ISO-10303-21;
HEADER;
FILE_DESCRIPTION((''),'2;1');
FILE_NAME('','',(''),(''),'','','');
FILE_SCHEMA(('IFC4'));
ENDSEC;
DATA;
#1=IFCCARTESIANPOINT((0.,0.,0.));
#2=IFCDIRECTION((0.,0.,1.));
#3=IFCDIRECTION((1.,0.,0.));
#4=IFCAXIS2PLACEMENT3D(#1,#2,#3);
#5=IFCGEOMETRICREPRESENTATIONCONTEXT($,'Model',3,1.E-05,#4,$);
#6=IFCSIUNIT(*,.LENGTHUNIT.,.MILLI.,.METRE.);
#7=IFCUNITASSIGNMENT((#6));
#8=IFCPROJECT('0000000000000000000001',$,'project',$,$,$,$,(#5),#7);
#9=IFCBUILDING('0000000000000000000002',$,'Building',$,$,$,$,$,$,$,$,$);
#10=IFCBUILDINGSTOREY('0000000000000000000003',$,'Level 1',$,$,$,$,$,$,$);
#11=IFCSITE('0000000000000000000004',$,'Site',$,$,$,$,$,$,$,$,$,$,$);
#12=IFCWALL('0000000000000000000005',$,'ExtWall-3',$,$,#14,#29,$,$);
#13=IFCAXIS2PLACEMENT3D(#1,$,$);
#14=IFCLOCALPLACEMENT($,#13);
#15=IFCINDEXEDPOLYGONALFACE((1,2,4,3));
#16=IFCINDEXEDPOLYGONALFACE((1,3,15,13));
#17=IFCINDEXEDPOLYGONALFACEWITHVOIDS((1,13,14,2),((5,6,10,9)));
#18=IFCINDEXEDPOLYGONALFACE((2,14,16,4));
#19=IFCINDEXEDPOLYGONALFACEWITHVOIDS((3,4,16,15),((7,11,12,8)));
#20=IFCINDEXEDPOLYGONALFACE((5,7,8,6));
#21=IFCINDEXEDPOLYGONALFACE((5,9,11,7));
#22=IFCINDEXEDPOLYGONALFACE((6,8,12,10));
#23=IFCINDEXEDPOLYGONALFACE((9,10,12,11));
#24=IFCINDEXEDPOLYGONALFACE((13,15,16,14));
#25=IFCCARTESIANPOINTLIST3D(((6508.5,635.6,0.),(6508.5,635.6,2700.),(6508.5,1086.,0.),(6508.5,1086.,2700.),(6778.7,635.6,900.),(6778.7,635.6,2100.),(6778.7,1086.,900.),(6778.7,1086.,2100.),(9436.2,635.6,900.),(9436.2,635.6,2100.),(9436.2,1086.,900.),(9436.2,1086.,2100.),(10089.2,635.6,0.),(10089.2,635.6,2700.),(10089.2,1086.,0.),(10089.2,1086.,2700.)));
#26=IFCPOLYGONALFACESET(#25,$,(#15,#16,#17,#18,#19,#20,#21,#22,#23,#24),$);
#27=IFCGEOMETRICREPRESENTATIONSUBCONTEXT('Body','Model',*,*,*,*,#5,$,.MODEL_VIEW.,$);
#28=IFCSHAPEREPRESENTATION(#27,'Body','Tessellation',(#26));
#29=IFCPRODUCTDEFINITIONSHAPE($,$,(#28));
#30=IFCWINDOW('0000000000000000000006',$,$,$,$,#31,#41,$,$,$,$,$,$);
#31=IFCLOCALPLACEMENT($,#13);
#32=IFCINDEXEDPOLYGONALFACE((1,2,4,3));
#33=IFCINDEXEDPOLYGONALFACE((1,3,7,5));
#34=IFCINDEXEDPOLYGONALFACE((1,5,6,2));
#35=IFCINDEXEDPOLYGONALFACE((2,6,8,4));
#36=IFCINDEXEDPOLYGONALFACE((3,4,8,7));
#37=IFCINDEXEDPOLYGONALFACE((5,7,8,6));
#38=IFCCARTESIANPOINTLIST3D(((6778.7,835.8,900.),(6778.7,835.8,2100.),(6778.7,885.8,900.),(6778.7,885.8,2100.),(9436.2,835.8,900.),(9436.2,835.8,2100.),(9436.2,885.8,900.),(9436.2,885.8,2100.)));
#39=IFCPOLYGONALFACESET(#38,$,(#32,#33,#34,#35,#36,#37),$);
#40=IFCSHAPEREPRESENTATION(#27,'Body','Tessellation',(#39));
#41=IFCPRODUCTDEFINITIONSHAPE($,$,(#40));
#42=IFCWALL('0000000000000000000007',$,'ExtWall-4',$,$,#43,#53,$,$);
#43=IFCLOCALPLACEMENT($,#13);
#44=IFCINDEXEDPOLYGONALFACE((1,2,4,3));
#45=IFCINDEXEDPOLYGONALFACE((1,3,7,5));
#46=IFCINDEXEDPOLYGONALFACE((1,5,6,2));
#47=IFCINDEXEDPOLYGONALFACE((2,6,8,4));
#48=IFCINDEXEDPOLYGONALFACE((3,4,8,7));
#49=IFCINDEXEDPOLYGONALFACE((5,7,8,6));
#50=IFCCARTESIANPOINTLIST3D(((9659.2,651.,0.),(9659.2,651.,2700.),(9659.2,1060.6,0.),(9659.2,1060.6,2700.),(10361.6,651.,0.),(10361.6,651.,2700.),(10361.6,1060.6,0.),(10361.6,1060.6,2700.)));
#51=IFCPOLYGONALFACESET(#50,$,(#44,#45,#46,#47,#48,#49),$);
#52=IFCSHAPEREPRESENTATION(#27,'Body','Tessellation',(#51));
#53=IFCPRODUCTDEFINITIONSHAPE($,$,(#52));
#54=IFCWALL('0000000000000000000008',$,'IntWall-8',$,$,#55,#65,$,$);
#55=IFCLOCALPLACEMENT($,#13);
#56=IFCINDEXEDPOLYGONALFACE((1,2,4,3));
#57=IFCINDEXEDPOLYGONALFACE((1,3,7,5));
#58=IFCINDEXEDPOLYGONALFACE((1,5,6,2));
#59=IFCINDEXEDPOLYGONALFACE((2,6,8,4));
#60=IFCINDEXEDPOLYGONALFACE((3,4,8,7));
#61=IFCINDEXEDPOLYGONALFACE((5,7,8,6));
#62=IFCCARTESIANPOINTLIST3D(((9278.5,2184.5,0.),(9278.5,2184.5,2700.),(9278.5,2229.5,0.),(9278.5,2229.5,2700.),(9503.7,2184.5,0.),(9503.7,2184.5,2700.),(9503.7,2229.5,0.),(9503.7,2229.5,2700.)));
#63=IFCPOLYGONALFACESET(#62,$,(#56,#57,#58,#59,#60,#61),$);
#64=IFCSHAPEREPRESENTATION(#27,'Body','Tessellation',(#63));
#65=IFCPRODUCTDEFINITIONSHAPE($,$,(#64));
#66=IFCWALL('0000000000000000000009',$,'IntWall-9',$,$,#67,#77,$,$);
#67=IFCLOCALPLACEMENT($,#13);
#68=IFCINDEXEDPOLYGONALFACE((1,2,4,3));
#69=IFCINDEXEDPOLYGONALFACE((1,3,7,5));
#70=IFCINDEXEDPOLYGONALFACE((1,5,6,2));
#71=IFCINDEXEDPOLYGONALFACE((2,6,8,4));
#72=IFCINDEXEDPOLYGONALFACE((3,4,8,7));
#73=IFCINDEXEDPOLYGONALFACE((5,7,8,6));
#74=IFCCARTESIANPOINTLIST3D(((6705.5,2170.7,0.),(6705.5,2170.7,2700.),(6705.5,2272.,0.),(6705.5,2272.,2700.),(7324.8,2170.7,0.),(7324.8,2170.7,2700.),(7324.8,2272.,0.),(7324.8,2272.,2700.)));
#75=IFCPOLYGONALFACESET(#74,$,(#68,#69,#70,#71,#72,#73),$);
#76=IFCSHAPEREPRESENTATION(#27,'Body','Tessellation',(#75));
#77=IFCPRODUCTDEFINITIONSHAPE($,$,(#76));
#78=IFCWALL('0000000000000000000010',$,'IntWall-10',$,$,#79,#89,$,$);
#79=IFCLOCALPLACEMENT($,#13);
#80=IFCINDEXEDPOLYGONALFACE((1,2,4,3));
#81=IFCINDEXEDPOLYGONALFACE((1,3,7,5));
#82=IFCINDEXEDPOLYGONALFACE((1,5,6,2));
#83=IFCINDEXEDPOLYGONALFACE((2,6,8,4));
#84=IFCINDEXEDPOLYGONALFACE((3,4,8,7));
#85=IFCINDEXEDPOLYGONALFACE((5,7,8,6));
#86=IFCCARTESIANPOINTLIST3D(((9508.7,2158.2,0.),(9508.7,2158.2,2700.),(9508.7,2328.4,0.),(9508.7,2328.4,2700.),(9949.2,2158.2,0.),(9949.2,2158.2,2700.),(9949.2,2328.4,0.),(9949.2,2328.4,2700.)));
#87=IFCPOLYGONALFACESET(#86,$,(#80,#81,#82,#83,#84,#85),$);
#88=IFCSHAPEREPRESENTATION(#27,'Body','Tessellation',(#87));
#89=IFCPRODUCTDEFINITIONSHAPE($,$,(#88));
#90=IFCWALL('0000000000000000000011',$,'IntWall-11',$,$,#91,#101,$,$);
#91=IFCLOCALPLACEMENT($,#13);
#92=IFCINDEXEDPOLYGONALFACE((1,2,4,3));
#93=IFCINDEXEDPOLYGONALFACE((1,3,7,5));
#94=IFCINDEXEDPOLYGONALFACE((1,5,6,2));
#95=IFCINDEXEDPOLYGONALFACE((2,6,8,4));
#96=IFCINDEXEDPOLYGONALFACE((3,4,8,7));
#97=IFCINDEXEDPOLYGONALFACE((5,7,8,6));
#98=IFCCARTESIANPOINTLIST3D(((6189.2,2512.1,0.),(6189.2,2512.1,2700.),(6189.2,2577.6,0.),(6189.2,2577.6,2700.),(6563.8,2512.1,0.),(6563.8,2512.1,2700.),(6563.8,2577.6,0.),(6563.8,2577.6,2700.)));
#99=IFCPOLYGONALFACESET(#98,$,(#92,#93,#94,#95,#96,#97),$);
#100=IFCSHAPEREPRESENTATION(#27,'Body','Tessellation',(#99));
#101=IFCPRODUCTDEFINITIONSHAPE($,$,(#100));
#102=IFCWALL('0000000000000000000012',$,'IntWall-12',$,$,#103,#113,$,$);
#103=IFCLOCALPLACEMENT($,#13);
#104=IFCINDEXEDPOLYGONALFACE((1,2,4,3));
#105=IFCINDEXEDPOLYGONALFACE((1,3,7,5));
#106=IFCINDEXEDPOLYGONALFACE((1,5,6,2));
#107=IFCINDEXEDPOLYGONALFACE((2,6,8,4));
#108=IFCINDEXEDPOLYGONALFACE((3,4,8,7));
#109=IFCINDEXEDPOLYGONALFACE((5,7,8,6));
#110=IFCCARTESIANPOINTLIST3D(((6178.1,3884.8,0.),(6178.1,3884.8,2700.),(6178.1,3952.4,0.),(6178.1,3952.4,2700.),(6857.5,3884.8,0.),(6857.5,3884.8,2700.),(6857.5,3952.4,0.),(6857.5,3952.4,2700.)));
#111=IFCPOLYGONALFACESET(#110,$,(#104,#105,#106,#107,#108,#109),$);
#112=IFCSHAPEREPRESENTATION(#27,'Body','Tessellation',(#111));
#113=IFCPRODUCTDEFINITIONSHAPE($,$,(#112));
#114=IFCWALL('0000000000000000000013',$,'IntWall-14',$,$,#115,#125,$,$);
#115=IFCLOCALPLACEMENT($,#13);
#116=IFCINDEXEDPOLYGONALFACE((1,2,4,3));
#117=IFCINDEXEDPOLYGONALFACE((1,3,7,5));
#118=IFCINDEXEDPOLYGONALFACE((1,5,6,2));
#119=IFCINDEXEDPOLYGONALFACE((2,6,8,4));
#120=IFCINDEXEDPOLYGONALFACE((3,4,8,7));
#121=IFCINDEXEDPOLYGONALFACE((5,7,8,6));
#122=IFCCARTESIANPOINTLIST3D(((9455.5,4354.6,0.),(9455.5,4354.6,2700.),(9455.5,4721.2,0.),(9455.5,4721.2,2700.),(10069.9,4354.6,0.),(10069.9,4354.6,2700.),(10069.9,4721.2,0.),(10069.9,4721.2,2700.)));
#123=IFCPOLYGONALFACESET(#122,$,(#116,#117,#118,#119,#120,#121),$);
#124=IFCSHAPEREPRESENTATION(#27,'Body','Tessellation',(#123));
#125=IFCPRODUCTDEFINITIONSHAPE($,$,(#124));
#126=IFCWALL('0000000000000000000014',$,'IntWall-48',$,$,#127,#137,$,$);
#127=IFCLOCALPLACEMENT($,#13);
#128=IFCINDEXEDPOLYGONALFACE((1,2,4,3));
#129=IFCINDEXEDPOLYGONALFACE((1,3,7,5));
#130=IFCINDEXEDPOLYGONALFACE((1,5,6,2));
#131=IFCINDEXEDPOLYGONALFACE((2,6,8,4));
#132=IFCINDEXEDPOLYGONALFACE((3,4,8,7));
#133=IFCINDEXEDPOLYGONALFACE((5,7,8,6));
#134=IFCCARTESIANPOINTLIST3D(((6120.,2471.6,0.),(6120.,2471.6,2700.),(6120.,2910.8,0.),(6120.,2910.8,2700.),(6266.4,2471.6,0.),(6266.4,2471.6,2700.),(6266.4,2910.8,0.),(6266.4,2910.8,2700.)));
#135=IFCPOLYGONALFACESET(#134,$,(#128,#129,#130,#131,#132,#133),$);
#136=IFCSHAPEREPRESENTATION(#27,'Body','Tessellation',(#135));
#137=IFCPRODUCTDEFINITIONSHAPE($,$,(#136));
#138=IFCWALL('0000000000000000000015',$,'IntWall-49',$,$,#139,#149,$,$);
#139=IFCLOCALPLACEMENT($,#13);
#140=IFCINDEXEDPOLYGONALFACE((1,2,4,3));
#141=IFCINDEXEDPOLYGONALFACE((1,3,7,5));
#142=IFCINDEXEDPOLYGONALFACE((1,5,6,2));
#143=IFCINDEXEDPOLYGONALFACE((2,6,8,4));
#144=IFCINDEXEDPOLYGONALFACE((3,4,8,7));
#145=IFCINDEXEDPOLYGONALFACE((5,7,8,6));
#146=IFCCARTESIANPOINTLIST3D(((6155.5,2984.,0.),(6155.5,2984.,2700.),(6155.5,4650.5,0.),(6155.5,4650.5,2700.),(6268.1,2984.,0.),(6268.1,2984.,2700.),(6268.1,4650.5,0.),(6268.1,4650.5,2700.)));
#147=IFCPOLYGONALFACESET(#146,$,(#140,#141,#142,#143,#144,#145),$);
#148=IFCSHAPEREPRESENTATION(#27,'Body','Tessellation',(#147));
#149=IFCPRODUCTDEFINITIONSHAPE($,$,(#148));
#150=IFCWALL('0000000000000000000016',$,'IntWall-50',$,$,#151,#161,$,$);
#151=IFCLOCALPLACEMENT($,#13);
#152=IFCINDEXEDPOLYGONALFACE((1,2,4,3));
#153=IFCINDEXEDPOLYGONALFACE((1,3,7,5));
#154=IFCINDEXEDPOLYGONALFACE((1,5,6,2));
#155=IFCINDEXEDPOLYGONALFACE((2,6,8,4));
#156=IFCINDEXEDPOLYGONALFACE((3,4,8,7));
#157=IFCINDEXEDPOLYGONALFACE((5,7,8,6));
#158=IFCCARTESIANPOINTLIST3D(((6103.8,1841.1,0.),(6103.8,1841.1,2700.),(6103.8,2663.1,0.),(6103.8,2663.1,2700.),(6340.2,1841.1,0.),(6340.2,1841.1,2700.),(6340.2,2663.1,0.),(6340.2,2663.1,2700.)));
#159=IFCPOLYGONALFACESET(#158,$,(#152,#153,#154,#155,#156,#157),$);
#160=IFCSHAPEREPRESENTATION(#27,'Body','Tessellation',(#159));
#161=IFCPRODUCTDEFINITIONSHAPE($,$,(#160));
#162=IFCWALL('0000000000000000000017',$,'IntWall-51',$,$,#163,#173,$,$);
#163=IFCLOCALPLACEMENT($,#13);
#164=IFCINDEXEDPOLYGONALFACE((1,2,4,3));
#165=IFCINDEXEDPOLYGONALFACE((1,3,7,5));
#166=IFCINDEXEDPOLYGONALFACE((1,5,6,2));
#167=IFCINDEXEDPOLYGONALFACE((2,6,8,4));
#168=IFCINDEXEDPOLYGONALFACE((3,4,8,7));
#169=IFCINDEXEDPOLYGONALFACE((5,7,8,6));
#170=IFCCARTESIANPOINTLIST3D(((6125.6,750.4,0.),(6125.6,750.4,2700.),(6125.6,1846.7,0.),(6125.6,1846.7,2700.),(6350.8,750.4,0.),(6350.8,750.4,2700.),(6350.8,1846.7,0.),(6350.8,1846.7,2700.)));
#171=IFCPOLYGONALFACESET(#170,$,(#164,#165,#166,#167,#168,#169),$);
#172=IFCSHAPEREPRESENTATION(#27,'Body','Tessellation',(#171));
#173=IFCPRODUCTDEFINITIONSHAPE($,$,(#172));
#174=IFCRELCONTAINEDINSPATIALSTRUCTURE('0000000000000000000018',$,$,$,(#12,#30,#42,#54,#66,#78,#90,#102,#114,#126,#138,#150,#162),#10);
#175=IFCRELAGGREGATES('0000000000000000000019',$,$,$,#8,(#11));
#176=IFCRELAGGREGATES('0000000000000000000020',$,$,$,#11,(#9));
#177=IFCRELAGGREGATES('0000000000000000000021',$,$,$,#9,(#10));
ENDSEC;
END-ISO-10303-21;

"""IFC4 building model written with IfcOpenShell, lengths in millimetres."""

from ifc_helpers import new_model, si_unit, frame, origin_with_axes, place, context, subcontext, project, spatial, indexed_curve, outline, extrude, element, fill, save


model = new_model("IFC4")

# Units and contexts
model_context = context("Model", 3, precision=1e-05, world=origin_with_axes())
body_context = subcontext(model_context, "Body", "Model", "MODEL_VIEW")
ifc_project = project(units=[si_unit("LENGTHUNIT", "METRE", prefix="MILLI")], contexts=[model_context])

# Site, building, storey
site = spatial("IfcSite", under=ifc_project, Name="Site")
building = spatial("IfcBuilding", under=site, Name="Building")
storey = spatial("IfcBuildingStorey", under=building, Name="Level 1")

# Wall, opening, window
wall_1_placement = place(None, frame((6508.5, 860.8, 0.0), z_axis=(0.0, 0.0, 1.0), x_axis=(1.0, 0.0, 0.0)))
wall_1 = element("IfcWall", 1, at=wall_1_placement, inside=storey, Name="ExtWall-3", context=body_context, shape_type="SweptSolid", body=[
    extrude(outline(indexed_curve([(0.0, 0.0), (0.0, 450.4), (3580.8, 450.4), (3580.8, 0.0), (0.0, 0.0)], self_intersect=False)), frame((0.0, -225.2, 0.0), z_axis=(0.0, 0.0, 1.0), x_axis=(1.0, 0.0, 0.0)), (0.0, 0.0, 1.0), 2700.0),
])
opening_1_placement = place(wall_1_placement, frame((270.2, 0.0, 900.0), z_axis=(0.0, 0.0, 1.0), x_axis=(1.0, 0.0, 0.0)))
opening_1 = element("IfcOpeningElement", 2, at=opening_1_placement, cuts=wall_1, context=body_context, shape_type="SweptSolid", body=[
    extrude(outline(indexed_curve([(0.0, 0.0), (0.0, 550.4), (2657.4, 550.4), (2657.4, 0.0), (0.0, 0.0)], self_intersect=False)), frame((0.0, -275.2, 0.0), z_axis=(0.0, 0.0, 1.0), x_axis=(1.0, 0.0, 0.0)), (0.0, 0.0, 1.0), 1200.0),
])
window_1_placement = place(opening_1_placement, origin_with_axes())
window_1 = element("IfcWindow", 3, at=window_1_placement, inside=storey, context=body_context, shape_type="SweptSolid", body=[
    extrude(outline(indexed_curve([(0.0, 0.0), (0.0, 50.0), (2657.4, 50.0), (2657.4, 0.0), (0.0, 0.0)], self_intersect=False)), frame((0.0, -25.0, 0.0), z_axis=(0.0, 0.0, 1.0), x_axis=(1.0, 0.0, 0.0)), (0.0, 0.0, 1.0), 1200.0),
])
fill(opening_1, window_1)

# Walls
wall_2_placement = place(None, frame((9659.2, 855.8, 0.0), z_axis=(0.0, 0.0, 1.0), x_axis=(1.0, 0.0, 0.0)))
element("IfcWall", 4, at=wall_2_placement, inside=storey, Name="ExtWall-4", context=body_context, shape_type="SweptSolid", body=[
    extrude(outline(indexed_curve([(0.0, 0.0), (0.0, 409.7), (702.4, 409.7), (702.4, 0.0), (0.0, 0.0)], self_intersect=False)), frame((0.0, -204.8, 0.0), z_axis=(0.0, 0.0, 1.0), x_axis=(1.0, 0.0, 0.0)), (0.0, 0.0, 1.0), 2700.0),
])
wall_3_placement = place(None, frame((9278.5, 2207.0, 0.0), z_axis=(0.0, 0.0, 1.0), x_axis=(1.0, 0.0, 0.0)))
element("IfcWall", 5, at=wall_3_placement, inside=storey, Name="IntWall-8", context=body_context, shape_type="SweptSolid", body=[
    extrude(outline(indexed_curve([(0.0, 0.0), (0.0, 45.0), (225.2, 45.0), (225.2, 0.0), (0.0, 0.0)], self_intersect=False)), frame((0.0, -22.5, 0.0), z_axis=(0.0, 0.0, 1.0), x_axis=(1.0, 0.0, 0.0)), (0.0, 0.0, 1.0), 2700.0),
])
wall_4_placement = place(None, frame((6705.5, 2221.4, 0.0), z_axis=(0.0, 0.0, 1.0), x_axis=(1.0, 0.0, 0.0)))
element("IfcWall", 6, at=wall_4_placement, inside=storey, Name="IntWall-9", context=body_context, shape_type="SweptSolid", body=[
    extrude(outline(indexed_curve([(0.0, 0.0), (0.0, 101.3), (619.3, 101.3), (619.3, 0.0), (0.0, 0.0)], self_intersect=False)), frame((0.0, -50.7, 0.0), z_axis=(0.0, 0.0, 1.0), x_axis=(1.0, 0.0, 0.0)), (0.0, 0.0, 1.0), 2700.0),
])
wall_5_placement = place(None, frame((9508.7, 2243.3, 0.0), z_axis=(0.0, 0.0, 1.0), x_axis=(1.0, 0.0, 0.0)))
element("IfcWall", 7, at=wall_5_placement, inside=storey, Name="IntWall-10", context=body_context, shape_type="SweptSolid", body=[
    extrude(outline(indexed_curve([(0.0, 0.0), (0.0, 170.2), (440.5, 170.2), (440.5, 0.0), (0.0, 0.0)], self_intersect=False)), frame((0.0, -85.1, 0.0), z_axis=(0.0, 0.0, 1.0), x_axis=(1.0, 0.0, 0.0)), (0.0, 0.0, 1.0), 2700.0),
])
wall_6_placement = place(None, frame((6189.2, 2544.8, 0.0), z_axis=(0.0, 0.0, 1.0), x_axis=(1.0, 0.0, 0.0)))
element("IfcWall", 8, at=wall_6_placement, inside=storey, Name="IntWall-11", context=body_context, shape_type="SweptSolid", body=[
    extrude(outline(indexed_curve([(0.0, 0.0), (0.0, 65.5), (374.5, 65.5), (374.5, 0.0), (0.0, 0.0)], self_intersect=False)), frame((0.0, -32.8, 0.0), z_axis=(0.0, 0.0, 1.0), x_axis=(1.0, 0.0, 0.0)), (0.0, 0.0, 1.0), 2700.0),
])
wall_7_placement = place(None, frame((6178.1, 3918.6, 0.0), z_axis=(0.0, 0.0, 1.0), x_axis=(1.0, 0.0, 0.0)))
element("IfcWall", 9, at=wall_7_placement, inside=storey, Name="IntWall-12", context=body_context, shape_type="SweptSolid", body=[
    extrude(outline(indexed_curve([(0.0, 0.0), (0.0, 67.6), (679.5, 67.6), (679.5, 0.0), (0.0, 0.0)], self_intersect=False)), frame((0.0, -33.8, 0.0), z_axis=(0.0, 0.0, 1.0), x_axis=(1.0, 0.0, 0.0)), (0.0, 0.0, 1.0), 2700.0),
])
wall_8_placement = place(None, frame((9455.5, 4537.9, 0.0), z_axis=(0.0, 0.0, 1.0), x_axis=(1.0, 0.0, 0.0)))
element("IfcWall", 10, at=wall_8_placement, inside=storey, Name="IntWall-14", context=body_context, shape_type="SweptSolid", body=[
    extrude(outline(indexed_curve([(0.0, 0.0), (0.0, 366.6), (614.4, 366.6), (614.4, 0.0), (0.0, 0.0)], self_intersect=False)), frame((0.0, -183.3, 0.0), z_axis=(0.0, 0.0, 1.0), x_axis=(1.0, 0.0, 0.0)), (0.0, 0.0, 1.0), 2700.0),
])
wall_9_placement = place(None, frame((6193.2, 2471.6, 0.0), z_axis=(0.0, 0.0, 1.0), x_axis=(0.0, 1.0, 0.0)))
element("IfcWall", 11, at=wall_9_placement, inside=storey, Name="IntWall-48", context=body_context, shape_type="SweptSolid", body=[
    extrude(outline(indexed_curve([(0.0, 0.0), (0.0, 146.4), (439.2, 146.4), (439.2, 0.0), (0.0, 0.0)], self_intersect=False)), frame((0.0, -73.2, 0.0), z_axis=(0.0, 0.0, 1.0), x_axis=(1.0, 0.0, 0.0)), (0.0, 0.0, 1.0), 2700.0),
])
wall_10_placement = place(None, frame((6211.8, 2984.0, 0.0), z_axis=(0.0, 0.0, 1.0), x_axis=(0.0, 1.0, 0.0)))
element("IfcWall", 12, at=wall_10_placement, inside=storey, Name="IntWall-49", context=body_context, shape_type="SweptSolid", body=[
    extrude(outline(indexed_curve([(0.0, 0.0), (0.0, 112.6), (1666.5, 112.6), (1666.5, 0.0), (0.0, 0.0)], self_intersect=False)), frame((0.0, -56.3, 0.0), z_axis=(0.0, 0.0, 1.0), x_axis=(1.0, 0.0, 0.0)), (0.0, 0.0, 1.0), 2700.0),
])
wall_11_placement = place(None, frame((6222.0, 1841.1, 0.0), z_axis=(0.0, 0.0, 1.0), x_axis=(0.0, 1.0, 0.0)))
element("IfcWall", 13, at=wall_11_placement, inside=storey, Name="IntWall-50", context=body_context, shape_type="SweptSolid", body=[
    extrude(outline(indexed_curve([(0.0, 0.0), (0.0, 236.5), (822.0, 236.5), (822.0, 0.0), (0.0, 0.0)], self_intersect=False)), frame((0.0, -118.2, 0.0), z_axis=(0.0, 0.0, 1.0), x_axis=(1.0, 0.0, 0.0)), (0.0, 0.0, 1.0), 2700.0),
])
wall_12_placement = place(None, frame((6238.2, 750.4, 0.0), z_axis=(0.0, 0.0, 1.0), x_axis=(0.0, 1.0, 0.0)))
element("IfcWall", 14, at=wall_12_placement, inside=storey, Name="IntWall-51", context=body_context, shape_type="SweptSolid", body=[
    extrude(outline(indexed_curve([(0.0, 0.0), (0.0, 225.2), (1096.3, 225.2), (1096.3, 0.0), (0.0, 0.0)], self_intersect=False)), frame((0.0, -112.6, 0.0), z_axis=(0.0, 0.0, 1.0), x_axis=(1.0, 0.0, 0.0)), (0.0, 0.0, 1.0), 2700.0),
])

save(model, "model.ifc")
